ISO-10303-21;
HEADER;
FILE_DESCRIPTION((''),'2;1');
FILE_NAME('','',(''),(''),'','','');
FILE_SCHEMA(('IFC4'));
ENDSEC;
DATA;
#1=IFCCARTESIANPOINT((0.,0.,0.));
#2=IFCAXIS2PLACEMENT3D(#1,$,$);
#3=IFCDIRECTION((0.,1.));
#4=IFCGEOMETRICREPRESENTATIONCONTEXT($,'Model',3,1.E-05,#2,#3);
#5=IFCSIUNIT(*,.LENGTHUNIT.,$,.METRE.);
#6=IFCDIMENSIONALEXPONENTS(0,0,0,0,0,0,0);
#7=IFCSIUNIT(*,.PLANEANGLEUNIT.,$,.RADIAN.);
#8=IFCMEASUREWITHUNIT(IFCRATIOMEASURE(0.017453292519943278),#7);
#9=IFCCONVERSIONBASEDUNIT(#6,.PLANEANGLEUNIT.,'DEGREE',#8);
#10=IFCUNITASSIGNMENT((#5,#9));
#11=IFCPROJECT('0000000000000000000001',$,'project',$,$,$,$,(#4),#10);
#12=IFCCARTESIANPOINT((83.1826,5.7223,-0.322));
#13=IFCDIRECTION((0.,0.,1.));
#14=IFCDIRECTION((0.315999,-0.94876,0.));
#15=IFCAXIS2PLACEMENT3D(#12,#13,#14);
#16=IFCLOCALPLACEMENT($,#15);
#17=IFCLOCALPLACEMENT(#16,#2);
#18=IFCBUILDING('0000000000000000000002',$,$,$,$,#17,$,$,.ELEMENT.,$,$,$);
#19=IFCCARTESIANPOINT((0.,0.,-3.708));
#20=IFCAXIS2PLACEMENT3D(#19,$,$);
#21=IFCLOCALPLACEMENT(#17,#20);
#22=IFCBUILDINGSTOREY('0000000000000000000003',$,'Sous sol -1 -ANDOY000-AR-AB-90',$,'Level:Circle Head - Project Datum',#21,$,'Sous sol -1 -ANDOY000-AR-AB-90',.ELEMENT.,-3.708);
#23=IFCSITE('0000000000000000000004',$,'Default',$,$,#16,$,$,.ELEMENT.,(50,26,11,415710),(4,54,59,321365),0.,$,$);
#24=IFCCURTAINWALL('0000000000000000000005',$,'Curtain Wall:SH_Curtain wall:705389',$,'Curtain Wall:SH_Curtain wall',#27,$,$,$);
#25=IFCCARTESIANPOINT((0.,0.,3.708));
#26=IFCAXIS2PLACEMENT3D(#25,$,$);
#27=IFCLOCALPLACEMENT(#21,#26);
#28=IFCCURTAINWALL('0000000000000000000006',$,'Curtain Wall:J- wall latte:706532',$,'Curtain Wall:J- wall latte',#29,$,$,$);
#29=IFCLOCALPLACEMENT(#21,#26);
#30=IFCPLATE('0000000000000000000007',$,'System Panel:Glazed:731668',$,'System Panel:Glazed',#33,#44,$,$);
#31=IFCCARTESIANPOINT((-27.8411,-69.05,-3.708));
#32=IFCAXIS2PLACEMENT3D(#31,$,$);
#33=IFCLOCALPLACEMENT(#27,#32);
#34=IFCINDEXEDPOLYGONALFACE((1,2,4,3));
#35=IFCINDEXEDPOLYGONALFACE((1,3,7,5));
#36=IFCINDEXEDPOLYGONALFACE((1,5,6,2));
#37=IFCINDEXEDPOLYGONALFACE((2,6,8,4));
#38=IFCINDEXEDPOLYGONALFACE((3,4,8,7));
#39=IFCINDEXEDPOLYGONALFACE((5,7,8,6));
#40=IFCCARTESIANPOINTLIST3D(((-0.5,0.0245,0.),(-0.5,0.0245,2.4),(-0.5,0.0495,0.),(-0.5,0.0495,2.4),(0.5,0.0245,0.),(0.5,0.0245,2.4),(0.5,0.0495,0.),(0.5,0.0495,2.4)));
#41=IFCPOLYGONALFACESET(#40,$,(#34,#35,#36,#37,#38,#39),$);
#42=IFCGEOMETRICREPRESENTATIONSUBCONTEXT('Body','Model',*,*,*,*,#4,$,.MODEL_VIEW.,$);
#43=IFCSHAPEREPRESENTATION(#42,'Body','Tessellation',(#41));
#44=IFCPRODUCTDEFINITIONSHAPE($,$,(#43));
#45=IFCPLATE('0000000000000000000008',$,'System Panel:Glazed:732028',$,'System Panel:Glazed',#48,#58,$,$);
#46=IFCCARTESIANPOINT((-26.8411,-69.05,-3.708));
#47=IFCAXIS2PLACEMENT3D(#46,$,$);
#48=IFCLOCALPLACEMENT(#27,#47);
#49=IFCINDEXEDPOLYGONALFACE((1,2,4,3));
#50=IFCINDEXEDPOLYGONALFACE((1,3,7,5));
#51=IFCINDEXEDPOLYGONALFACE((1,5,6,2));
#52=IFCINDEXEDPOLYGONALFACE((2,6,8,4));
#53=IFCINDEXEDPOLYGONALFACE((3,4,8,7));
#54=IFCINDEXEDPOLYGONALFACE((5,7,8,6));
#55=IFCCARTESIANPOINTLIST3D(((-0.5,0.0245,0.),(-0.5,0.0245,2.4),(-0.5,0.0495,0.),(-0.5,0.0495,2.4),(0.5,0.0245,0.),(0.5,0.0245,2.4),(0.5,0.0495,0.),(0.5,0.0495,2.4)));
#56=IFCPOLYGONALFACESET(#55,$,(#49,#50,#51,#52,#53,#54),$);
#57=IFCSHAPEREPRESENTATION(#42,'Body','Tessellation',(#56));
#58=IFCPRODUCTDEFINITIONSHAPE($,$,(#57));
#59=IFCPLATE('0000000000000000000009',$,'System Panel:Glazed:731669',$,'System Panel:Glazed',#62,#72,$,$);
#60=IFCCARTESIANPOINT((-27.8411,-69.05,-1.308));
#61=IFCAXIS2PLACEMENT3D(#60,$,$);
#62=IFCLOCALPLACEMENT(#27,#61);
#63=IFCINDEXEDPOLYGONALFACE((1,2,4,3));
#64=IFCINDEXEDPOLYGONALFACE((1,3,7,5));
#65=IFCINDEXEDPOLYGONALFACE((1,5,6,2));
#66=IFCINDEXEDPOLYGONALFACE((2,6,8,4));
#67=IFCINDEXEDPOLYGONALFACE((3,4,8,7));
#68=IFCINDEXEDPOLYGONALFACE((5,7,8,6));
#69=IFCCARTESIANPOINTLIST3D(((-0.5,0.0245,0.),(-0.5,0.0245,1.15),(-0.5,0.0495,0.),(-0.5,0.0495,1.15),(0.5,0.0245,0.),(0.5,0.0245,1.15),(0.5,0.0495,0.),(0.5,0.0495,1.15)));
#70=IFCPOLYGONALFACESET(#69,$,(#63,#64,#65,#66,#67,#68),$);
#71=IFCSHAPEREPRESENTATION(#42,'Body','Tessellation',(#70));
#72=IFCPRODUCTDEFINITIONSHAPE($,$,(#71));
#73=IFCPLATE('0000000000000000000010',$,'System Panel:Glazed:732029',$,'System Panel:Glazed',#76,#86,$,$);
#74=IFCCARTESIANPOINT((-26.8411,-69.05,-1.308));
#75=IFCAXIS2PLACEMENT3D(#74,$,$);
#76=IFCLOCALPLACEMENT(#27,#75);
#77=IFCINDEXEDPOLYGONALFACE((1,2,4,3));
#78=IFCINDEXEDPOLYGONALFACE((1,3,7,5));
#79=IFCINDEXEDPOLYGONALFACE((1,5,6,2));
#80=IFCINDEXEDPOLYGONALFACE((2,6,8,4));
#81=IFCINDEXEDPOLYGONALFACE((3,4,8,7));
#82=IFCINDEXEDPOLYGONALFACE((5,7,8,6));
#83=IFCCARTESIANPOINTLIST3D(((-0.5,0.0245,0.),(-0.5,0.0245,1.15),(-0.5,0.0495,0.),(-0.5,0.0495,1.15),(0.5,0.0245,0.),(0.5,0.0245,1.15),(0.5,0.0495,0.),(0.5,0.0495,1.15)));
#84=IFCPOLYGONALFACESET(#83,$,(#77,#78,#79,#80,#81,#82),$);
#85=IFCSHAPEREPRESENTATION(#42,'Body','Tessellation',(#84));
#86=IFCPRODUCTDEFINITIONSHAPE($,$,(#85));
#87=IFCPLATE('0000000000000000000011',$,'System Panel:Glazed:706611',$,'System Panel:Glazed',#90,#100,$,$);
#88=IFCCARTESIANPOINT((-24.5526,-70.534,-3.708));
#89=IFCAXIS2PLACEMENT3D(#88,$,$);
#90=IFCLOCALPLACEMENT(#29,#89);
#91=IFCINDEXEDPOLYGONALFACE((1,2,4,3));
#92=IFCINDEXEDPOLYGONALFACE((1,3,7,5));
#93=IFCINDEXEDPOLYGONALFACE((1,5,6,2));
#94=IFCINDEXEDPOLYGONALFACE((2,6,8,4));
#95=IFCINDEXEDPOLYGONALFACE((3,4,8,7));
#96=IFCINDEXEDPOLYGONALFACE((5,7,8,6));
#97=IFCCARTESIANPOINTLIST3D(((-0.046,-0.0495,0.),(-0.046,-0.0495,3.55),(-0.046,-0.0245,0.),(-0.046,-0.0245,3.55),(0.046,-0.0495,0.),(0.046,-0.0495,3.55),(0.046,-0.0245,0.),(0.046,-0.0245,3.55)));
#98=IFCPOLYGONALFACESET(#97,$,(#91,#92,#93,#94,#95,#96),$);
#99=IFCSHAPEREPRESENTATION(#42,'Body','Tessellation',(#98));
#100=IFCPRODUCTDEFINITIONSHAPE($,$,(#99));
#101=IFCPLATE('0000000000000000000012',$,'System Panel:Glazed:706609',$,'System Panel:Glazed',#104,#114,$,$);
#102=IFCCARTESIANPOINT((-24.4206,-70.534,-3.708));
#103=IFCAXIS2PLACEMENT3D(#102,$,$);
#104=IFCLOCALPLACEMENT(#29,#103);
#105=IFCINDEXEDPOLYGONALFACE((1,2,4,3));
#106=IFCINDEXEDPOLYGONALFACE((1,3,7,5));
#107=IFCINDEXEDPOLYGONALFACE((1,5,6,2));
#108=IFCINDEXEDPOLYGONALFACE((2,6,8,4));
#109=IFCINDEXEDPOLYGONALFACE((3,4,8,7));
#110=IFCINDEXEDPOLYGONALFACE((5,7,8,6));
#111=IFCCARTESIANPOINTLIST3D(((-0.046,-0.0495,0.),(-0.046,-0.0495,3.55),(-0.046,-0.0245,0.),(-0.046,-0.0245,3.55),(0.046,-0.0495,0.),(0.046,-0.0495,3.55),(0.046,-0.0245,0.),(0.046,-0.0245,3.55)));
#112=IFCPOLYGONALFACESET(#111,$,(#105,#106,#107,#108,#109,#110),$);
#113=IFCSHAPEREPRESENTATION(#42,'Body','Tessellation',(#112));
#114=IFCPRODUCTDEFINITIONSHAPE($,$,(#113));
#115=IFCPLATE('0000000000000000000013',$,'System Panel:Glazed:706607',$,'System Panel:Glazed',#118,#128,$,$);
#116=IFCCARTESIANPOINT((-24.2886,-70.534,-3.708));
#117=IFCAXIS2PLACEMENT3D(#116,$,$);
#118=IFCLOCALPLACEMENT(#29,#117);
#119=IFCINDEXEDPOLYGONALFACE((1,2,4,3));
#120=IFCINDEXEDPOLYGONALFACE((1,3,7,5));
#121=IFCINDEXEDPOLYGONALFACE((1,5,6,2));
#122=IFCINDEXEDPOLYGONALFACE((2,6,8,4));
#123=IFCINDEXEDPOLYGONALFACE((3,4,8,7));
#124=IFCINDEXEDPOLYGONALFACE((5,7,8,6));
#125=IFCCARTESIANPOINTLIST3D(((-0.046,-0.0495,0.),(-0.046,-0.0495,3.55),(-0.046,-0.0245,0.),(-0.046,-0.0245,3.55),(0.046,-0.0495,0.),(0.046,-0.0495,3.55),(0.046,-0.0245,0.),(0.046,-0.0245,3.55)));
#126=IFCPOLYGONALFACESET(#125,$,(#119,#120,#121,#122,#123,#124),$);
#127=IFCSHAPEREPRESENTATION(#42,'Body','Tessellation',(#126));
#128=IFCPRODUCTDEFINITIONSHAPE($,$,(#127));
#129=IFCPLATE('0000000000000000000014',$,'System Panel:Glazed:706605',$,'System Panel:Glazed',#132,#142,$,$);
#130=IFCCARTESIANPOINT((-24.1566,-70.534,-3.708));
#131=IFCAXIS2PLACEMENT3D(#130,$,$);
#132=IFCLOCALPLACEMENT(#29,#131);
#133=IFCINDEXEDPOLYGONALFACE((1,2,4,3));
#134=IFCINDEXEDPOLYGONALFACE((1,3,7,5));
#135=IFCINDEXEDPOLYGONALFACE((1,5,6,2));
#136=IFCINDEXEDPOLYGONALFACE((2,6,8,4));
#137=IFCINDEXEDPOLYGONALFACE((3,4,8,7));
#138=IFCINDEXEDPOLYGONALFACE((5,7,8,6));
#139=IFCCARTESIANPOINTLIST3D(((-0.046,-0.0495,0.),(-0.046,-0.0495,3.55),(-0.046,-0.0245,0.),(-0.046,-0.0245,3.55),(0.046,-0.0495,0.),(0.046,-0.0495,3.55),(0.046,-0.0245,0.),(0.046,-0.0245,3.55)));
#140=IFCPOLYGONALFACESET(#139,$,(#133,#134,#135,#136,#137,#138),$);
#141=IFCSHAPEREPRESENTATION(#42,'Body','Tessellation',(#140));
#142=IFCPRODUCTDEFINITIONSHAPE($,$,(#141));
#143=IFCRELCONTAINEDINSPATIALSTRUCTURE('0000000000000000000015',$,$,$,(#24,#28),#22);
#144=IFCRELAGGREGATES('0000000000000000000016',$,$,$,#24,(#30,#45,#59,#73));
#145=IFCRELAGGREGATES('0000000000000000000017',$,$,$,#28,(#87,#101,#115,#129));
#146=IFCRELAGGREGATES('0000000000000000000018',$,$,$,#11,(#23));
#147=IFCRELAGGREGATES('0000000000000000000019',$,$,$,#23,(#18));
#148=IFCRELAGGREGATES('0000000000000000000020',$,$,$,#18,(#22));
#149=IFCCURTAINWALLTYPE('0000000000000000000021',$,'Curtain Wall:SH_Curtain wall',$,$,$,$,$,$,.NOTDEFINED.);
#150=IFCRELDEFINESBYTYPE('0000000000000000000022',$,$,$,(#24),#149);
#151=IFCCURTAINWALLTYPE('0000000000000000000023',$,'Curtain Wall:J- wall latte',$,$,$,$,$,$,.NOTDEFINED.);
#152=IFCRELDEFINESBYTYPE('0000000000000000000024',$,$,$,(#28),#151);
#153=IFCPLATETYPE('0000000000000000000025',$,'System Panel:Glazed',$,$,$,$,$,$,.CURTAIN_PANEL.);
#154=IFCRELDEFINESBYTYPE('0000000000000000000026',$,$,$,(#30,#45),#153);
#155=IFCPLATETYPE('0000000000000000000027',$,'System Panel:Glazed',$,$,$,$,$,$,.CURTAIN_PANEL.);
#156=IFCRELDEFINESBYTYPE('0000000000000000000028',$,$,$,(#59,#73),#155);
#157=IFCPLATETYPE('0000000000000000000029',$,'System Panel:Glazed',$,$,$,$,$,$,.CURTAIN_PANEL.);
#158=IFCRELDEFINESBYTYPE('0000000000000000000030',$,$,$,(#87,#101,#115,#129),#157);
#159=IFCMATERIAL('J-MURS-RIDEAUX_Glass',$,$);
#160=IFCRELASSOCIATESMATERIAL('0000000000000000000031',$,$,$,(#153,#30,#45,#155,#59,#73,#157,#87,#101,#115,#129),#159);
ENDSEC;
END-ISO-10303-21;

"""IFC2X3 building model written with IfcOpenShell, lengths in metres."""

from ifc_helpers import new_model, entity, si_unit, converted_unit, direction, frame, frame_2d, origin, origin_2d_with_axis, place, context, subcontext, project, spatial, rectangle, extrude, source, transform, mapped, material, type_object, type_shapes, element, aggregate, save


model = new_model("IFC2X3")

# Units and contexts
model_context = context("Model", 3, precision=1e-05, world=origin(), true_north=direction((0.0, 1.0)))
body_context = subcontext(model_context, "Body", "Model", "MODEL_VIEW")
ifc_project = project(units=[si_unit("LENGTHUNIT", "METRE"), converted_unit("PLANEANGLEUNIT", "DEGREE", entity("IfcRatioMeasure", 0.017453292519943278), si_unit("PLANEANGLEUNIT", "RADIAN"), dimensions=[0, 0, 0, 0, 0, 0, 0])], contexts=[model_context])

# Site, building, storey
site_placement = place(None, frame((83.1826, 5.7223, -0.322), z_axis=(0.0, 0.0, 1.0), x_axis=(0.315999, -0.94876, 0.0)))
site = spatial("IfcSite", under=ifc_project, at=site_placement, Name="Default", CompositionType="ELEMENT", RefLatitude=(50, 26, 11, 415710), RefLongitude=(4, 54, 59, 321365), RefElevation=0.0)
building_placement = place(site_placement, origin())
building = spatial("IfcBuilding", under=site, at=building_placement, CompositionType="ELEMENT")
storey_placement = place(building_placement, frame((0.0, 0.0, -3.708)))
storey = spatial("IfcBuildingStorey", under=building, at=storey_placement, Name="Sous sol -1 -ANDOY000-AR-AB-90", ObjectType="Level:Circle Head - Project Datum", LongName="Sous sol -1 -ANDOY000-AR-AB-90", CompositionType="ELEMENT", Elevation=-3.708)

# Curtain walls
curtain_wall_type_1 = type_object("IfcCurtainWallType", Name="Curtain Wall:SH_Curtain wall", PredefinedType="NOTDEFINED")
curtain_wall_1_placement = place(storey_placement, frame((0.0, 0.0, 3.708)))
curtain_wall_1 = element("IfcCurtainWall", 1, at=curtain_wall_1_placement, inside=storey, type_object=curtain_wall_type_1, Name="Curtain Wall:SH_Curtain wall:705389", ObjectType="Curtain Wall:SH_Curtain wall")
curtain_wall_type_2 = type_object("IfcCurtainWallType", Name="Curtain Wall:J- wall latte", PredefinedType="NOTDEFINED")
curtain_wall_2_placement = place(storey_placement, frame((0.0, 0.0, 3.708)))
curtain_wall_2 = element("IfcCurtainWall", 2, at=curtain_wall_2_placement, inside=storey, type_object=curtain_wall_type_2, Name="Curtain Wall:J- wall latte:706532", ObjectType="Curtain Wall:J- wall latte")

# Plates
ifc_material_1 = material(Name="J-MURS-RIDEAUX_Glass")
plate_type_1 = type_object("IfcPlateType", Name="System Panel:Glazed", PredefinedType="CURTAIN_PANEL", material=ifc_material_1)
shared_shape_1 = source(origin(), body_context, "Body", "SweptSolid", [
    extrude(rectangle(XDim=0.025, YDim=1.0, at=frame_2d((0.0, 0.0), x_axis=(1.0, 0.0))), frame((0.0, 0.037, 0.0), z_axis=(0.0, 0.0, 1.0), x_axis=(0.0, 1.0, 0.0)), (0.0, 0.0, 1.0), 2.4),
])
type_shapes(plate_type_1, [shared_shape_1])
plate_1_placement = place(curtain_wall_1_placement, frame((-27.8411, -69.05, -3.708)))
plate_1 = element("IfcPlate", 3, at=plate_1_placement, type_object=plate_type_1, material=ifc_material_1, Name="System Panel:Glazed:731668", ObjectType="System Panel:Glazed", context=body_context, shape_type="MappedRepresentation", body=[
    mapped(shared_shape_1, transform((0.0, 0.0, 0.0), scale=1.0)),
])
plate_2_placement = place(curtain_wall_1_placement, frame((-26.8411, -69.05, -3.708)))
plate_2 = element("IfcPlate", 4, at=plate_2_placement, type_object=plate_type_1, material=ifc_material_1, Name="System Panel:Glazed:732028", ObjectType="System Panel:Glazed", context=body_context, shape_type="MappedRepresentation", body=[
    mapped(shared_shape_1, transform((0.0, 0.0, 0.0), scale=1.0)),
])
plate_type_2 = type_object("IfcPlateType", Name="System Panel:Glazed", PredefinedType="CURTAIN_PANEL", material=ifc_material_1)
shared_shape_2 = source(origin(), body_context, "Body", "SweptSolid", [
    extrude(rectangle(XDim=0.025, YDim=1.0, at=origin_2d_with_axis()), frame((0.0, 0.037, 0.0), z_axis=(0.0, 0.0, 1.0), x_axis=(0.0, 1.0, 0.0)), (0.0, 0.0, 1.0), 1.15),
])
type_shapes(plate_type_2, [shared_shape_2])
plate_3_placement = place(curtain_wall_1_placement, frame((-27.8411, -69.05, -1.308)))
plate_3 = element("IfcPlate", 5, at=plate_3_placement, type_object=plate_type_2, material=ifc_material_1, Name="System Panel:Glazed:731669", ObjectType="System Panel:Glazed", context=body_context, shape_type="MappedRepresentation", body=[
    mapped(shared_shape_2, transform((0.0, 0.0, 0.0), scale=1.0)),
])
plate_4_placement = place(curtain_wall_1_placement, frame((-26.8411, -69.05, -1.308)))
plate_4 = element("IfcPlate", 6, at=plate_4_placement, type_object=plate_type_2, material=ifc_material_1, Name="System Panel:Glazed:732029", ObjectType="System Panel:Glazed", context=body_context, shape_type="MappedRepresentation", body=[
    mapped(shared_shape_2, transform((0.0, 0.0, 0.0), scale=1.0)),
])
aggregate(curtain_wall_1, [plate_1, plate_2, plate_3, plate_4])
plate_type_3 = type_object("IfcPlateType", Name="System Panel:Glazed", PredefinedType="CURTAIN_PANEL", material=ifc_material_1)
shared_shape_3 = source(origin(), body_context, "Body", "SweptSolid", [
    extrude(rectangle(XDim=0.025, YDim=0.092, at=frame_2d((0.0, 0.0), x_axis=(1.0, 0.0))), frame((0.0, -0.037, 0.0), z_axis=(0.0, 0.0, 1.0), x_axis=(0.0, 1.0, 0.0)), (0.0, 0.0, 1.0), 3.55),
])
type_shapes(plate_type_3, [shared_shape_3])
plate_5_placement = place(curtain_wall_2_placement, frame((-24.5526, -70.534, -3.708)))
plate_5 = element("IfcPlate", 7, at=plate_5_placement, type_object=plate_type_3, material=ifc_material_1, Name="System Panel:Glazed:706611", ObjectType="System Panel:Glazed", context=body_context, shape_type="MappedRepresentation", body=[
    mapped(shared_shape_3, transform((0.0, 0.0, 0.0), scale=1.0)),
])
plate_6_placement = place(curtain_wall_2_placement, frame((-24.4206, -70.534, -3.708)))
plate_6 = element("IfcPlate", 8, at=plate_6_placement, type_object=plate_type_3, material=ifc_material_1, Name="System Panel:Glazed:706609", ObjectType="System Panel:Glazed", context=body_context, shape_type="MappedRepresentation", body=[
    mapped(shared_shape_3, transform((0.0, 0.0, 0.0), scale=1.0)),
])
plate_7_placement = place(curtain_wall_2_placement, frame((-24.2886, -70.534, -3.708)))
plate_7 = element("IfcPlate", 9, at=plate_7_placement, type_object=plate_type_3, material=ifc_material_1, Name="System Panel:Glazed:706607", ObjectType="System Panel:Glazed", context=body_context, shape_type="MappedRepresentation", body=[
    mapped(shared_shape_3, transform((0.0, 0.0, 0.0), scale=1.0)),
])
plate_8_placement = place(curtain_wall_2_placement, frame((-24.1566, -70.534, -3.708)))
plate_8 = element("IfcPlate", 10, at=plate_8_placement, type_object=plate_type_3, material=ifc_material_1, Name="System Panel:Glazed:706605", ObjectType="System Panel:Glazed", context=body_context, shape_type="MappedRepresentation", body=[
    mapped(shared_shape_3, transform((0.0, 0.0, 0.0), scale=1.0)),
])
aggregate(curtain_wall_2, [plate_5, plate_6, plate_7, plate_8])

save(model, "model.ifc")
